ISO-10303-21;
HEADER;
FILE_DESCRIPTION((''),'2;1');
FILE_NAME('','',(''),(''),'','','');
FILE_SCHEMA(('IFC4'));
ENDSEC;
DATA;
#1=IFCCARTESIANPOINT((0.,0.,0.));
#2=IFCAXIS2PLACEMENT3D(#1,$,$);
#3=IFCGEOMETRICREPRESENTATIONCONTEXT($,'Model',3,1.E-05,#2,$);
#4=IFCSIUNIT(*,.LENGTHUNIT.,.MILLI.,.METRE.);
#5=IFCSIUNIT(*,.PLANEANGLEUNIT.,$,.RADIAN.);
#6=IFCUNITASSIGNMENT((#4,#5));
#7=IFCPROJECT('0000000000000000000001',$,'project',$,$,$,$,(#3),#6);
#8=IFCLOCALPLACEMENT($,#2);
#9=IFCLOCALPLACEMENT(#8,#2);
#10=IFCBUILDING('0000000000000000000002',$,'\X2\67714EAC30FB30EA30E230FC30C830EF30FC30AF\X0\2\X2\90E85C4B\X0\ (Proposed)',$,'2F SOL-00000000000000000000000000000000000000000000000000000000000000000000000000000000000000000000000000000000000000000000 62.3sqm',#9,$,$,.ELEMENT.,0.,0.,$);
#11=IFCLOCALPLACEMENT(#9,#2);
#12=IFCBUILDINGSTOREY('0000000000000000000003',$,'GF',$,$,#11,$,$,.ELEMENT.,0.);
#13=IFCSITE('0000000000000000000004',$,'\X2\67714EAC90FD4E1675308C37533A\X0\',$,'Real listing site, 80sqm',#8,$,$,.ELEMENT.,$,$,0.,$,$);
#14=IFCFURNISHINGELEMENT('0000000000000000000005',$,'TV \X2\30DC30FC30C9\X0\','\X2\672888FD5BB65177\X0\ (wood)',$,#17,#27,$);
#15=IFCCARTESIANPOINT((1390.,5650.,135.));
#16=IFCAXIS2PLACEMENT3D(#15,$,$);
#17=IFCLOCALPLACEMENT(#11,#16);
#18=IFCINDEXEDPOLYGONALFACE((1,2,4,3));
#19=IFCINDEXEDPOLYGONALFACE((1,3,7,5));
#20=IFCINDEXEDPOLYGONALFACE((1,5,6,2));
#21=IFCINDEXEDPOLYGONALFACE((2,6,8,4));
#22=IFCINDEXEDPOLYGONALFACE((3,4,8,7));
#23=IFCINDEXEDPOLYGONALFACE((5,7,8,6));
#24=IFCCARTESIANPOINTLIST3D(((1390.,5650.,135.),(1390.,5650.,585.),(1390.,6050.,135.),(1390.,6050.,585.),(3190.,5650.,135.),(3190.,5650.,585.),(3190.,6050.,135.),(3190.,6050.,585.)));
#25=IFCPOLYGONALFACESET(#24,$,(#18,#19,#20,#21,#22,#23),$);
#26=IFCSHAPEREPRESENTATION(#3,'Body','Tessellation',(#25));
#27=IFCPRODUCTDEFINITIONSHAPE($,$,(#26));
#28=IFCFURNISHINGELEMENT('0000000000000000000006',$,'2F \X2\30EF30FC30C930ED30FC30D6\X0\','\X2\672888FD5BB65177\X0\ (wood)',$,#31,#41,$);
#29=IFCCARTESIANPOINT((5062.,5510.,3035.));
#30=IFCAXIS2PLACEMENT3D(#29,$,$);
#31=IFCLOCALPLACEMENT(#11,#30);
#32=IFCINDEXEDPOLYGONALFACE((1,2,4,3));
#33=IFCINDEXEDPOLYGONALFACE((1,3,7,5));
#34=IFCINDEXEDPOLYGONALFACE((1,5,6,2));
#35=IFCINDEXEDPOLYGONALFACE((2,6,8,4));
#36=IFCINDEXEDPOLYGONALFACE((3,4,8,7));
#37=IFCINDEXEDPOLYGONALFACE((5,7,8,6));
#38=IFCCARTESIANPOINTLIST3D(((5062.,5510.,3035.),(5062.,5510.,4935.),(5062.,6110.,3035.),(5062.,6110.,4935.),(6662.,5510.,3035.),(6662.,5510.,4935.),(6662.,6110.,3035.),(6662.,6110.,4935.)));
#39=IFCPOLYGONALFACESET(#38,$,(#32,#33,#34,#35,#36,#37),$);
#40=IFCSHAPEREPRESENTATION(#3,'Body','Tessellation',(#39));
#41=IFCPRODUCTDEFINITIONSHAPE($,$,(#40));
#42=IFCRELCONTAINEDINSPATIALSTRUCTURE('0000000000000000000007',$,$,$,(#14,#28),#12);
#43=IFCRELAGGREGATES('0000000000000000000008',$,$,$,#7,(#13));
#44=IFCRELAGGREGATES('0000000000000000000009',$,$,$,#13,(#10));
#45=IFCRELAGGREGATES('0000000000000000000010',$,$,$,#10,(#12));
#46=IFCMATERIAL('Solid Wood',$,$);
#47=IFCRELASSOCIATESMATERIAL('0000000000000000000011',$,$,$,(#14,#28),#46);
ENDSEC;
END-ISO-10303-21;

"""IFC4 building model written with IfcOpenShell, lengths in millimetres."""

from ifc_helpers import new_model, si_unit, frame, frame_2d, origin, place, context, project, spatial, rectangle, extrude, material, element, save


model = new_model("IFC4")

# Units and contexts
model_context = context("Model", 3, precision=1e-05, world=origin())
ifc_project = project(units=[si_unit("LENGTHUNIT", "METRE", prefix="MILLI"), si_unit("PLANEANGLEUNIT", "RADIAN")], contexts=[model_context])

# Site, building, storey
site_placement = place(None, origin())
site = spatial("IfcSite", under=ifc_project, at=site_placement, Name="東京都世田谷区", ObjectType="Real listing site, 80sqm", CompositionType="ELEMENT", RefElevation=0.0)
building_placement = place(site_placement, origin())
building = spatial("IfcBuilding", under=site, at=building_placement, Name="東京・リモートワーク2部屋 (Proposed)", ObjectType="2F SOL-00000000000000000000000000000000000000000000000000000000000000000000000000000000000000000000000000000000000000000000 62.3sqm", CompositionType="ELEMENT", ElevationOfRefHeight=0.0, ElevationOfTerrain=0.0)
storey_placement = place(building_placement, origin())
storey = spatial("IfcBuildingStorey", under=building, at=storey_placement, Name="GF", CompositionType="ELEMENT", Elevation=0.0)

# Shared definitions
ifc_material_1 = material(Name="Solid Wood")

# Furnishing elements
furnishing_1_placement = place(storey_placement, frame((1390.0, 5650.0, 135.0)))
element("IfcFurnishingElement", 1, at=furnishing_1_placement, inside=storey, material=ifc_material_1, Name="TV ボード", Description="木製家具 (wood)", context=model_context, shape_type="SweptSolid", body=[
    extrude(rectangle(XDim=1800.0, YDim=400.0, at=frame_2d((900.0, 200.0))), frame((1390.0, 5650.0, 135.0)), (0.0, 0.0, 1.0), 450.0),
])
furnishing_2_placement = place(storey_placement, frame((5062.0, 5510.0, 3035.0)))
element("IfcFurnishingElement", 2, at=furnishing_2_placement, inside=storey, material=ifc_material_1, Name="2F ワードローブ", Description="木製家具 (wood)", context=model_context, shape_type="SweptSolid", body=[
    extrude(rectangle(XDim=1600.0, YDim=600.0, at=frame_2d((800.0, 300.0))), frame((5062.0, 5510.0, 3035.0)), (0.0, 0.0, 1.0), 1900.0),
])

save(model, "model.ifc")
